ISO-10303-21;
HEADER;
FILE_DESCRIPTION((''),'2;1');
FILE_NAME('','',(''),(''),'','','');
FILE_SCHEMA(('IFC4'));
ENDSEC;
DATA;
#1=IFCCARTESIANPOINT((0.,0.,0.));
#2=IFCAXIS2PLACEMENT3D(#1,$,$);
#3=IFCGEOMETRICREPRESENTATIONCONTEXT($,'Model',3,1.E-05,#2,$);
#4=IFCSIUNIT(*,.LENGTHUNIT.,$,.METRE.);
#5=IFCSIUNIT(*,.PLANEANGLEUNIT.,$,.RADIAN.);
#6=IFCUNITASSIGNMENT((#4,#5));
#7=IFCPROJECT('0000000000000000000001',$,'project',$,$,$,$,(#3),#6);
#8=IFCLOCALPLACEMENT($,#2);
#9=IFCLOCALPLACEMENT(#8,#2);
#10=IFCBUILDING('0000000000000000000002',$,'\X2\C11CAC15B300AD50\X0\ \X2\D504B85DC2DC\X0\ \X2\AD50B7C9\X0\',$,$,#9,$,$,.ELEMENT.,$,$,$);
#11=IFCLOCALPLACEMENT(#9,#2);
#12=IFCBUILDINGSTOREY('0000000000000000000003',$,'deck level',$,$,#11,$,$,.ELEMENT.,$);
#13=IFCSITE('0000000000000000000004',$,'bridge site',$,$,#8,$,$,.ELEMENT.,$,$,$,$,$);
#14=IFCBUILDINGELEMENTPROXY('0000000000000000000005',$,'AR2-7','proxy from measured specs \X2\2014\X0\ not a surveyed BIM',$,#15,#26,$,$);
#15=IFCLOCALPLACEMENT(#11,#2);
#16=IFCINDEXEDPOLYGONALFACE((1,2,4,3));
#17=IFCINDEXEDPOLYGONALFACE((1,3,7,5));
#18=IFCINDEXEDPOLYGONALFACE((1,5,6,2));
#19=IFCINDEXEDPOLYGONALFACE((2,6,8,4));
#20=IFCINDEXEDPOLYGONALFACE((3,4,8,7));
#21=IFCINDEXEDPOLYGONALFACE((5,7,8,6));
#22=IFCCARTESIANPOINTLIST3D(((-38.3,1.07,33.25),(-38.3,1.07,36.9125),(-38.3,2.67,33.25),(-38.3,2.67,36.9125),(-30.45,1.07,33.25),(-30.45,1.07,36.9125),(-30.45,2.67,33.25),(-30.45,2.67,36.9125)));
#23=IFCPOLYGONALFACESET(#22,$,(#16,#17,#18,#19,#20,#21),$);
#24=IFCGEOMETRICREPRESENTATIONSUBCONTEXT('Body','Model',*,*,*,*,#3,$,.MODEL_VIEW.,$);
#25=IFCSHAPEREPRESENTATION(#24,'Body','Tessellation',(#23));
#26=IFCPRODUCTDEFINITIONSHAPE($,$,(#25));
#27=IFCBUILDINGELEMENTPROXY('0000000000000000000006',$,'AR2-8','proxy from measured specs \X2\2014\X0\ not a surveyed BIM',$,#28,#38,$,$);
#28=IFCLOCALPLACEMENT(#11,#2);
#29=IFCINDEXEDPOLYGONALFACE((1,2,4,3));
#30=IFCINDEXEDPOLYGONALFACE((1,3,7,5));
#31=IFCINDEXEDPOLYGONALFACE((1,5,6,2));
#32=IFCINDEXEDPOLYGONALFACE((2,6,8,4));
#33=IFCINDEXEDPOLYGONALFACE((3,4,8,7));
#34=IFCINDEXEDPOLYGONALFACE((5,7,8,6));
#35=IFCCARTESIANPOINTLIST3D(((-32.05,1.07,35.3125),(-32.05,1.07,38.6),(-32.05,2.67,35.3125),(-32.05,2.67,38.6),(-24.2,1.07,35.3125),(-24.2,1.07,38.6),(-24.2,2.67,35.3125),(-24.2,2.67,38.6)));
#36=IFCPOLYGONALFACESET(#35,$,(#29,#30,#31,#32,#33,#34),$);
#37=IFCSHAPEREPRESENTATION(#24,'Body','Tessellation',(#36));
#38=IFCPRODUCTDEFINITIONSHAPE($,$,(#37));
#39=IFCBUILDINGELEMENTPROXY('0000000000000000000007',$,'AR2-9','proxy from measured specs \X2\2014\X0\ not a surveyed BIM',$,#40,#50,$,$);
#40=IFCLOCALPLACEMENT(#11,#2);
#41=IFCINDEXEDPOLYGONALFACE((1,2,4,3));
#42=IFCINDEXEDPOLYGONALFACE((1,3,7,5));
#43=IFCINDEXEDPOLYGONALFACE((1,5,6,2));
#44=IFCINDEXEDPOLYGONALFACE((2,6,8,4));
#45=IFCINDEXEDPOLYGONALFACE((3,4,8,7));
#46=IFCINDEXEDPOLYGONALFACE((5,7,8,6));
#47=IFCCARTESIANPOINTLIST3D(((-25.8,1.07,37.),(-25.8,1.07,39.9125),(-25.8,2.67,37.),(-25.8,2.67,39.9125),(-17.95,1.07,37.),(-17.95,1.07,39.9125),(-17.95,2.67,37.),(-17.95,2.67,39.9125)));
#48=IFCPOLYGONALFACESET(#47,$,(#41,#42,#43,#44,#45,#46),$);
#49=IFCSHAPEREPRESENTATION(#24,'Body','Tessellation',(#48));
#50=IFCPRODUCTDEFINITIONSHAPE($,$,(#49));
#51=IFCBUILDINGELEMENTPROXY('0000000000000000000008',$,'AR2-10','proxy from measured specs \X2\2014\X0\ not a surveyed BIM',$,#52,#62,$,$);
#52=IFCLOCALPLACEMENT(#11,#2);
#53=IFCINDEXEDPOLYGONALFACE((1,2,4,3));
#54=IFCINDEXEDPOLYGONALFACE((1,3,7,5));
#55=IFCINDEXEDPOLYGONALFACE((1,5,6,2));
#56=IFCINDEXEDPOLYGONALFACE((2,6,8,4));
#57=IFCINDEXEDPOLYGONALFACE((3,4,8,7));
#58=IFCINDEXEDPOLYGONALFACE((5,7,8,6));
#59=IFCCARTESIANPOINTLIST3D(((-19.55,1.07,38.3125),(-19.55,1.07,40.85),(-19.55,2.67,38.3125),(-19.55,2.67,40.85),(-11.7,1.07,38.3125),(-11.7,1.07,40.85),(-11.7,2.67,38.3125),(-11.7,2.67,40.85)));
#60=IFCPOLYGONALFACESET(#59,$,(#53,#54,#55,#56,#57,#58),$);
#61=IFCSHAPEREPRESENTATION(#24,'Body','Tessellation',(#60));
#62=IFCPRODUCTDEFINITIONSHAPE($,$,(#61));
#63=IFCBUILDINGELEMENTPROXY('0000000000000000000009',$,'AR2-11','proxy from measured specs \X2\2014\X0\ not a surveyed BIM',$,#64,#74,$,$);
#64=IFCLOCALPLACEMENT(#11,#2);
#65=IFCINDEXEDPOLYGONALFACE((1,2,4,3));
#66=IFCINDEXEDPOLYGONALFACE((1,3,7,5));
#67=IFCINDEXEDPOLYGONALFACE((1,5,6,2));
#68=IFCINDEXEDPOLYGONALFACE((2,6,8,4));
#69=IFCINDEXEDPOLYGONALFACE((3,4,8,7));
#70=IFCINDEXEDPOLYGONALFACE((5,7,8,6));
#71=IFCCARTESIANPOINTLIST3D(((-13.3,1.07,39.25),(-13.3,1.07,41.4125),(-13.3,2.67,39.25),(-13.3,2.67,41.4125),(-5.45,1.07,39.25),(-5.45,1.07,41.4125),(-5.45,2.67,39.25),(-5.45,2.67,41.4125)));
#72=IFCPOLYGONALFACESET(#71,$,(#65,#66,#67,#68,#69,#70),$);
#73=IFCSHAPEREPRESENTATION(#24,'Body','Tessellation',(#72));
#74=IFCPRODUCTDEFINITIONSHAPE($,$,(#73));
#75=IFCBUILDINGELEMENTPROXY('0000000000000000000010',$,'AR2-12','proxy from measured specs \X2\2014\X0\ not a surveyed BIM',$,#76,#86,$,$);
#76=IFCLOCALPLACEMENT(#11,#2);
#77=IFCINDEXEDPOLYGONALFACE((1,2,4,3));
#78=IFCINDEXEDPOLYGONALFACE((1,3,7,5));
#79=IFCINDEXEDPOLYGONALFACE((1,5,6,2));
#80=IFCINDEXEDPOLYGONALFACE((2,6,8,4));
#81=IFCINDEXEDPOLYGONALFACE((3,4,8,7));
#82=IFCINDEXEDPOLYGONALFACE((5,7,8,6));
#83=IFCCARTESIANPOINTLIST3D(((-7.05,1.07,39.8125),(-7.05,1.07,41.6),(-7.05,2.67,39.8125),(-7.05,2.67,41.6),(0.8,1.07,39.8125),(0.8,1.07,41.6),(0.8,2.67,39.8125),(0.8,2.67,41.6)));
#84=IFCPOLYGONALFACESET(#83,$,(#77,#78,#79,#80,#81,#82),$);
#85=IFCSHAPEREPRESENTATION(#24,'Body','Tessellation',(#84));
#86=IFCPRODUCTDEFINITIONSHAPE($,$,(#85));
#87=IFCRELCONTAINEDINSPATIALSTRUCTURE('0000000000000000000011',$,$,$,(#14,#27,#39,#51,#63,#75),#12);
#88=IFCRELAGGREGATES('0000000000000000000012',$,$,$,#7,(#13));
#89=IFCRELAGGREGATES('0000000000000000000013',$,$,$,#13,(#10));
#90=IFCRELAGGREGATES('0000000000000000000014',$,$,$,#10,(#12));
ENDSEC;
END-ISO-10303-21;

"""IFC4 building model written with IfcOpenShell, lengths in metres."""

from ifc_helpers import new_model, si_unit, frame, origin, origin_2d, place, context, subcontext, project, spatial, rectangle, extrude, element, save


model = new_model("IFC4")

# Units and contexts
model_context = context("Model", 3, precision=1e-05, world=origin())
body_context = subcontext(model_context, "Body", "Model", "MODEL_VIEW")
ifc_project = project(units=[si_unit("LENGTHUNIT", "METRE"), si_unit("PLANEANGLEUNIT", "RADIAN")], contexts=[model_context])

# Site, building, storey
site_placement = place(None, origin())
site = spatial("IfcSite", under=ifc_project, at=site_placement, Name="bridge site", CompositionType="ELEMENT")
building_placement = place(site_placement, origin())
building = spatial("IfcBuilding", under=site, at=building_placement, Name="서강대교 프록시 교량", CompositionType="ELEMENT")
storey_placement = place(building_placement, origin())
storey = spatial("IfcBuildingStorey", under=building, at=storey_placement, Name="deck level", CompositionType="ELEMENT")

# Building element proxies
proxy_1_placement = place(storey_placement, frame((-34.375, 1.87, 33.25)))
element("IfcBuildingElementProxy", 1, at=proxy_1_placement, inside=storey, Name="AR2-7", Description="proxy from measured specs — not a surveyed BIM", context=body_context, shape_type="SweptSolid", body=[
    extrude(rectangle(XDim=7.85, YDim=1.6, at=origin_2d()), origin(), (0.0, 0.0, 1.0), 3.6625),
])
proxy_2_placement = place(storey_placement, frame((-28.125, 1.87, 35.3125)))
element("IfcBuildingElementProxy", 2, at=proxy_2_placement, inside=storey, Name="AR2-8", Description="proxy from measured specs — not a surveyed BIM", context=body_context, shape_type="SweptSolid", body=[
    extrude(rectangle(XDim=7.85, YDim=1.6, at=origin_2d()), origin(), (0.0, 0.0, 1.0), 3.2875),
])
proxy_3_placement = place(storey_placement, frame((-21.875, 1.87, 37.0)))
element("IfcBuildingElementProxy", 3, at=proxy_3_placement, inside=storey, Name="AR2-9", Description="proxy from measured specs — not a surveyed BIM", context=body_context, shape_type="SweptSolid", body=[
    extrude(rectangle(XDim=7.85, YDim=1.6, at=origin_2d()), origin(), (0.0, 0.0, 1.0), 2.9125),
])
proxy_4_placement = place(storey_placement, frame((-15.625, 1.87, 38.3125)))
element("IfcBuildingElementProxy", 4, at=proxy_4_placement, inside=storey, Name="AR2-10", Description="proxy from measured specs — not a surveyed BIM", context=body_context, shape_type="SweptSolid", body=[
    extrude(rectangle(XDim=7.85, YDim=1.6, at=origin_2d()), origin(), (0.0, 0.0, 1.0), 2.5375),
])
proxy_5_placement = place(storey_placement, frame((-9.375, 1.87, 39.25)))
element("IfcBuildingElementProxy", 5, at=proxy_5_placement, inside=storey, Name="AR2-11", Description="proxy from measured specs — not a surveyed BIM", context=body_context, shape_type="SweptSolid", body=[
    extrude(rectangle(XDim=7.85, YDim=1.6, at=origin_2d()), origin(), (0.0, 0.0, 1.0), 2.1625),
])
proxy_6_placement = place(storey_placement, frame((-3.125, 1.87, 39.8125)))
element("IfcBuildingElementProxy", 6, at=proxy_6_placement, inside=storey, Name="AR2-12", Description="proxy from measured specs — not a surveyed BIM", context=body_context, shape_type="SweptSolid", body=[
    extrude(rectangle(XDim=7.85, YDim=1.6, at=origin_2d()), origin(), (0.0, 0.0, 1.0), 1.7875),
])

save(model, "model.ifc")
